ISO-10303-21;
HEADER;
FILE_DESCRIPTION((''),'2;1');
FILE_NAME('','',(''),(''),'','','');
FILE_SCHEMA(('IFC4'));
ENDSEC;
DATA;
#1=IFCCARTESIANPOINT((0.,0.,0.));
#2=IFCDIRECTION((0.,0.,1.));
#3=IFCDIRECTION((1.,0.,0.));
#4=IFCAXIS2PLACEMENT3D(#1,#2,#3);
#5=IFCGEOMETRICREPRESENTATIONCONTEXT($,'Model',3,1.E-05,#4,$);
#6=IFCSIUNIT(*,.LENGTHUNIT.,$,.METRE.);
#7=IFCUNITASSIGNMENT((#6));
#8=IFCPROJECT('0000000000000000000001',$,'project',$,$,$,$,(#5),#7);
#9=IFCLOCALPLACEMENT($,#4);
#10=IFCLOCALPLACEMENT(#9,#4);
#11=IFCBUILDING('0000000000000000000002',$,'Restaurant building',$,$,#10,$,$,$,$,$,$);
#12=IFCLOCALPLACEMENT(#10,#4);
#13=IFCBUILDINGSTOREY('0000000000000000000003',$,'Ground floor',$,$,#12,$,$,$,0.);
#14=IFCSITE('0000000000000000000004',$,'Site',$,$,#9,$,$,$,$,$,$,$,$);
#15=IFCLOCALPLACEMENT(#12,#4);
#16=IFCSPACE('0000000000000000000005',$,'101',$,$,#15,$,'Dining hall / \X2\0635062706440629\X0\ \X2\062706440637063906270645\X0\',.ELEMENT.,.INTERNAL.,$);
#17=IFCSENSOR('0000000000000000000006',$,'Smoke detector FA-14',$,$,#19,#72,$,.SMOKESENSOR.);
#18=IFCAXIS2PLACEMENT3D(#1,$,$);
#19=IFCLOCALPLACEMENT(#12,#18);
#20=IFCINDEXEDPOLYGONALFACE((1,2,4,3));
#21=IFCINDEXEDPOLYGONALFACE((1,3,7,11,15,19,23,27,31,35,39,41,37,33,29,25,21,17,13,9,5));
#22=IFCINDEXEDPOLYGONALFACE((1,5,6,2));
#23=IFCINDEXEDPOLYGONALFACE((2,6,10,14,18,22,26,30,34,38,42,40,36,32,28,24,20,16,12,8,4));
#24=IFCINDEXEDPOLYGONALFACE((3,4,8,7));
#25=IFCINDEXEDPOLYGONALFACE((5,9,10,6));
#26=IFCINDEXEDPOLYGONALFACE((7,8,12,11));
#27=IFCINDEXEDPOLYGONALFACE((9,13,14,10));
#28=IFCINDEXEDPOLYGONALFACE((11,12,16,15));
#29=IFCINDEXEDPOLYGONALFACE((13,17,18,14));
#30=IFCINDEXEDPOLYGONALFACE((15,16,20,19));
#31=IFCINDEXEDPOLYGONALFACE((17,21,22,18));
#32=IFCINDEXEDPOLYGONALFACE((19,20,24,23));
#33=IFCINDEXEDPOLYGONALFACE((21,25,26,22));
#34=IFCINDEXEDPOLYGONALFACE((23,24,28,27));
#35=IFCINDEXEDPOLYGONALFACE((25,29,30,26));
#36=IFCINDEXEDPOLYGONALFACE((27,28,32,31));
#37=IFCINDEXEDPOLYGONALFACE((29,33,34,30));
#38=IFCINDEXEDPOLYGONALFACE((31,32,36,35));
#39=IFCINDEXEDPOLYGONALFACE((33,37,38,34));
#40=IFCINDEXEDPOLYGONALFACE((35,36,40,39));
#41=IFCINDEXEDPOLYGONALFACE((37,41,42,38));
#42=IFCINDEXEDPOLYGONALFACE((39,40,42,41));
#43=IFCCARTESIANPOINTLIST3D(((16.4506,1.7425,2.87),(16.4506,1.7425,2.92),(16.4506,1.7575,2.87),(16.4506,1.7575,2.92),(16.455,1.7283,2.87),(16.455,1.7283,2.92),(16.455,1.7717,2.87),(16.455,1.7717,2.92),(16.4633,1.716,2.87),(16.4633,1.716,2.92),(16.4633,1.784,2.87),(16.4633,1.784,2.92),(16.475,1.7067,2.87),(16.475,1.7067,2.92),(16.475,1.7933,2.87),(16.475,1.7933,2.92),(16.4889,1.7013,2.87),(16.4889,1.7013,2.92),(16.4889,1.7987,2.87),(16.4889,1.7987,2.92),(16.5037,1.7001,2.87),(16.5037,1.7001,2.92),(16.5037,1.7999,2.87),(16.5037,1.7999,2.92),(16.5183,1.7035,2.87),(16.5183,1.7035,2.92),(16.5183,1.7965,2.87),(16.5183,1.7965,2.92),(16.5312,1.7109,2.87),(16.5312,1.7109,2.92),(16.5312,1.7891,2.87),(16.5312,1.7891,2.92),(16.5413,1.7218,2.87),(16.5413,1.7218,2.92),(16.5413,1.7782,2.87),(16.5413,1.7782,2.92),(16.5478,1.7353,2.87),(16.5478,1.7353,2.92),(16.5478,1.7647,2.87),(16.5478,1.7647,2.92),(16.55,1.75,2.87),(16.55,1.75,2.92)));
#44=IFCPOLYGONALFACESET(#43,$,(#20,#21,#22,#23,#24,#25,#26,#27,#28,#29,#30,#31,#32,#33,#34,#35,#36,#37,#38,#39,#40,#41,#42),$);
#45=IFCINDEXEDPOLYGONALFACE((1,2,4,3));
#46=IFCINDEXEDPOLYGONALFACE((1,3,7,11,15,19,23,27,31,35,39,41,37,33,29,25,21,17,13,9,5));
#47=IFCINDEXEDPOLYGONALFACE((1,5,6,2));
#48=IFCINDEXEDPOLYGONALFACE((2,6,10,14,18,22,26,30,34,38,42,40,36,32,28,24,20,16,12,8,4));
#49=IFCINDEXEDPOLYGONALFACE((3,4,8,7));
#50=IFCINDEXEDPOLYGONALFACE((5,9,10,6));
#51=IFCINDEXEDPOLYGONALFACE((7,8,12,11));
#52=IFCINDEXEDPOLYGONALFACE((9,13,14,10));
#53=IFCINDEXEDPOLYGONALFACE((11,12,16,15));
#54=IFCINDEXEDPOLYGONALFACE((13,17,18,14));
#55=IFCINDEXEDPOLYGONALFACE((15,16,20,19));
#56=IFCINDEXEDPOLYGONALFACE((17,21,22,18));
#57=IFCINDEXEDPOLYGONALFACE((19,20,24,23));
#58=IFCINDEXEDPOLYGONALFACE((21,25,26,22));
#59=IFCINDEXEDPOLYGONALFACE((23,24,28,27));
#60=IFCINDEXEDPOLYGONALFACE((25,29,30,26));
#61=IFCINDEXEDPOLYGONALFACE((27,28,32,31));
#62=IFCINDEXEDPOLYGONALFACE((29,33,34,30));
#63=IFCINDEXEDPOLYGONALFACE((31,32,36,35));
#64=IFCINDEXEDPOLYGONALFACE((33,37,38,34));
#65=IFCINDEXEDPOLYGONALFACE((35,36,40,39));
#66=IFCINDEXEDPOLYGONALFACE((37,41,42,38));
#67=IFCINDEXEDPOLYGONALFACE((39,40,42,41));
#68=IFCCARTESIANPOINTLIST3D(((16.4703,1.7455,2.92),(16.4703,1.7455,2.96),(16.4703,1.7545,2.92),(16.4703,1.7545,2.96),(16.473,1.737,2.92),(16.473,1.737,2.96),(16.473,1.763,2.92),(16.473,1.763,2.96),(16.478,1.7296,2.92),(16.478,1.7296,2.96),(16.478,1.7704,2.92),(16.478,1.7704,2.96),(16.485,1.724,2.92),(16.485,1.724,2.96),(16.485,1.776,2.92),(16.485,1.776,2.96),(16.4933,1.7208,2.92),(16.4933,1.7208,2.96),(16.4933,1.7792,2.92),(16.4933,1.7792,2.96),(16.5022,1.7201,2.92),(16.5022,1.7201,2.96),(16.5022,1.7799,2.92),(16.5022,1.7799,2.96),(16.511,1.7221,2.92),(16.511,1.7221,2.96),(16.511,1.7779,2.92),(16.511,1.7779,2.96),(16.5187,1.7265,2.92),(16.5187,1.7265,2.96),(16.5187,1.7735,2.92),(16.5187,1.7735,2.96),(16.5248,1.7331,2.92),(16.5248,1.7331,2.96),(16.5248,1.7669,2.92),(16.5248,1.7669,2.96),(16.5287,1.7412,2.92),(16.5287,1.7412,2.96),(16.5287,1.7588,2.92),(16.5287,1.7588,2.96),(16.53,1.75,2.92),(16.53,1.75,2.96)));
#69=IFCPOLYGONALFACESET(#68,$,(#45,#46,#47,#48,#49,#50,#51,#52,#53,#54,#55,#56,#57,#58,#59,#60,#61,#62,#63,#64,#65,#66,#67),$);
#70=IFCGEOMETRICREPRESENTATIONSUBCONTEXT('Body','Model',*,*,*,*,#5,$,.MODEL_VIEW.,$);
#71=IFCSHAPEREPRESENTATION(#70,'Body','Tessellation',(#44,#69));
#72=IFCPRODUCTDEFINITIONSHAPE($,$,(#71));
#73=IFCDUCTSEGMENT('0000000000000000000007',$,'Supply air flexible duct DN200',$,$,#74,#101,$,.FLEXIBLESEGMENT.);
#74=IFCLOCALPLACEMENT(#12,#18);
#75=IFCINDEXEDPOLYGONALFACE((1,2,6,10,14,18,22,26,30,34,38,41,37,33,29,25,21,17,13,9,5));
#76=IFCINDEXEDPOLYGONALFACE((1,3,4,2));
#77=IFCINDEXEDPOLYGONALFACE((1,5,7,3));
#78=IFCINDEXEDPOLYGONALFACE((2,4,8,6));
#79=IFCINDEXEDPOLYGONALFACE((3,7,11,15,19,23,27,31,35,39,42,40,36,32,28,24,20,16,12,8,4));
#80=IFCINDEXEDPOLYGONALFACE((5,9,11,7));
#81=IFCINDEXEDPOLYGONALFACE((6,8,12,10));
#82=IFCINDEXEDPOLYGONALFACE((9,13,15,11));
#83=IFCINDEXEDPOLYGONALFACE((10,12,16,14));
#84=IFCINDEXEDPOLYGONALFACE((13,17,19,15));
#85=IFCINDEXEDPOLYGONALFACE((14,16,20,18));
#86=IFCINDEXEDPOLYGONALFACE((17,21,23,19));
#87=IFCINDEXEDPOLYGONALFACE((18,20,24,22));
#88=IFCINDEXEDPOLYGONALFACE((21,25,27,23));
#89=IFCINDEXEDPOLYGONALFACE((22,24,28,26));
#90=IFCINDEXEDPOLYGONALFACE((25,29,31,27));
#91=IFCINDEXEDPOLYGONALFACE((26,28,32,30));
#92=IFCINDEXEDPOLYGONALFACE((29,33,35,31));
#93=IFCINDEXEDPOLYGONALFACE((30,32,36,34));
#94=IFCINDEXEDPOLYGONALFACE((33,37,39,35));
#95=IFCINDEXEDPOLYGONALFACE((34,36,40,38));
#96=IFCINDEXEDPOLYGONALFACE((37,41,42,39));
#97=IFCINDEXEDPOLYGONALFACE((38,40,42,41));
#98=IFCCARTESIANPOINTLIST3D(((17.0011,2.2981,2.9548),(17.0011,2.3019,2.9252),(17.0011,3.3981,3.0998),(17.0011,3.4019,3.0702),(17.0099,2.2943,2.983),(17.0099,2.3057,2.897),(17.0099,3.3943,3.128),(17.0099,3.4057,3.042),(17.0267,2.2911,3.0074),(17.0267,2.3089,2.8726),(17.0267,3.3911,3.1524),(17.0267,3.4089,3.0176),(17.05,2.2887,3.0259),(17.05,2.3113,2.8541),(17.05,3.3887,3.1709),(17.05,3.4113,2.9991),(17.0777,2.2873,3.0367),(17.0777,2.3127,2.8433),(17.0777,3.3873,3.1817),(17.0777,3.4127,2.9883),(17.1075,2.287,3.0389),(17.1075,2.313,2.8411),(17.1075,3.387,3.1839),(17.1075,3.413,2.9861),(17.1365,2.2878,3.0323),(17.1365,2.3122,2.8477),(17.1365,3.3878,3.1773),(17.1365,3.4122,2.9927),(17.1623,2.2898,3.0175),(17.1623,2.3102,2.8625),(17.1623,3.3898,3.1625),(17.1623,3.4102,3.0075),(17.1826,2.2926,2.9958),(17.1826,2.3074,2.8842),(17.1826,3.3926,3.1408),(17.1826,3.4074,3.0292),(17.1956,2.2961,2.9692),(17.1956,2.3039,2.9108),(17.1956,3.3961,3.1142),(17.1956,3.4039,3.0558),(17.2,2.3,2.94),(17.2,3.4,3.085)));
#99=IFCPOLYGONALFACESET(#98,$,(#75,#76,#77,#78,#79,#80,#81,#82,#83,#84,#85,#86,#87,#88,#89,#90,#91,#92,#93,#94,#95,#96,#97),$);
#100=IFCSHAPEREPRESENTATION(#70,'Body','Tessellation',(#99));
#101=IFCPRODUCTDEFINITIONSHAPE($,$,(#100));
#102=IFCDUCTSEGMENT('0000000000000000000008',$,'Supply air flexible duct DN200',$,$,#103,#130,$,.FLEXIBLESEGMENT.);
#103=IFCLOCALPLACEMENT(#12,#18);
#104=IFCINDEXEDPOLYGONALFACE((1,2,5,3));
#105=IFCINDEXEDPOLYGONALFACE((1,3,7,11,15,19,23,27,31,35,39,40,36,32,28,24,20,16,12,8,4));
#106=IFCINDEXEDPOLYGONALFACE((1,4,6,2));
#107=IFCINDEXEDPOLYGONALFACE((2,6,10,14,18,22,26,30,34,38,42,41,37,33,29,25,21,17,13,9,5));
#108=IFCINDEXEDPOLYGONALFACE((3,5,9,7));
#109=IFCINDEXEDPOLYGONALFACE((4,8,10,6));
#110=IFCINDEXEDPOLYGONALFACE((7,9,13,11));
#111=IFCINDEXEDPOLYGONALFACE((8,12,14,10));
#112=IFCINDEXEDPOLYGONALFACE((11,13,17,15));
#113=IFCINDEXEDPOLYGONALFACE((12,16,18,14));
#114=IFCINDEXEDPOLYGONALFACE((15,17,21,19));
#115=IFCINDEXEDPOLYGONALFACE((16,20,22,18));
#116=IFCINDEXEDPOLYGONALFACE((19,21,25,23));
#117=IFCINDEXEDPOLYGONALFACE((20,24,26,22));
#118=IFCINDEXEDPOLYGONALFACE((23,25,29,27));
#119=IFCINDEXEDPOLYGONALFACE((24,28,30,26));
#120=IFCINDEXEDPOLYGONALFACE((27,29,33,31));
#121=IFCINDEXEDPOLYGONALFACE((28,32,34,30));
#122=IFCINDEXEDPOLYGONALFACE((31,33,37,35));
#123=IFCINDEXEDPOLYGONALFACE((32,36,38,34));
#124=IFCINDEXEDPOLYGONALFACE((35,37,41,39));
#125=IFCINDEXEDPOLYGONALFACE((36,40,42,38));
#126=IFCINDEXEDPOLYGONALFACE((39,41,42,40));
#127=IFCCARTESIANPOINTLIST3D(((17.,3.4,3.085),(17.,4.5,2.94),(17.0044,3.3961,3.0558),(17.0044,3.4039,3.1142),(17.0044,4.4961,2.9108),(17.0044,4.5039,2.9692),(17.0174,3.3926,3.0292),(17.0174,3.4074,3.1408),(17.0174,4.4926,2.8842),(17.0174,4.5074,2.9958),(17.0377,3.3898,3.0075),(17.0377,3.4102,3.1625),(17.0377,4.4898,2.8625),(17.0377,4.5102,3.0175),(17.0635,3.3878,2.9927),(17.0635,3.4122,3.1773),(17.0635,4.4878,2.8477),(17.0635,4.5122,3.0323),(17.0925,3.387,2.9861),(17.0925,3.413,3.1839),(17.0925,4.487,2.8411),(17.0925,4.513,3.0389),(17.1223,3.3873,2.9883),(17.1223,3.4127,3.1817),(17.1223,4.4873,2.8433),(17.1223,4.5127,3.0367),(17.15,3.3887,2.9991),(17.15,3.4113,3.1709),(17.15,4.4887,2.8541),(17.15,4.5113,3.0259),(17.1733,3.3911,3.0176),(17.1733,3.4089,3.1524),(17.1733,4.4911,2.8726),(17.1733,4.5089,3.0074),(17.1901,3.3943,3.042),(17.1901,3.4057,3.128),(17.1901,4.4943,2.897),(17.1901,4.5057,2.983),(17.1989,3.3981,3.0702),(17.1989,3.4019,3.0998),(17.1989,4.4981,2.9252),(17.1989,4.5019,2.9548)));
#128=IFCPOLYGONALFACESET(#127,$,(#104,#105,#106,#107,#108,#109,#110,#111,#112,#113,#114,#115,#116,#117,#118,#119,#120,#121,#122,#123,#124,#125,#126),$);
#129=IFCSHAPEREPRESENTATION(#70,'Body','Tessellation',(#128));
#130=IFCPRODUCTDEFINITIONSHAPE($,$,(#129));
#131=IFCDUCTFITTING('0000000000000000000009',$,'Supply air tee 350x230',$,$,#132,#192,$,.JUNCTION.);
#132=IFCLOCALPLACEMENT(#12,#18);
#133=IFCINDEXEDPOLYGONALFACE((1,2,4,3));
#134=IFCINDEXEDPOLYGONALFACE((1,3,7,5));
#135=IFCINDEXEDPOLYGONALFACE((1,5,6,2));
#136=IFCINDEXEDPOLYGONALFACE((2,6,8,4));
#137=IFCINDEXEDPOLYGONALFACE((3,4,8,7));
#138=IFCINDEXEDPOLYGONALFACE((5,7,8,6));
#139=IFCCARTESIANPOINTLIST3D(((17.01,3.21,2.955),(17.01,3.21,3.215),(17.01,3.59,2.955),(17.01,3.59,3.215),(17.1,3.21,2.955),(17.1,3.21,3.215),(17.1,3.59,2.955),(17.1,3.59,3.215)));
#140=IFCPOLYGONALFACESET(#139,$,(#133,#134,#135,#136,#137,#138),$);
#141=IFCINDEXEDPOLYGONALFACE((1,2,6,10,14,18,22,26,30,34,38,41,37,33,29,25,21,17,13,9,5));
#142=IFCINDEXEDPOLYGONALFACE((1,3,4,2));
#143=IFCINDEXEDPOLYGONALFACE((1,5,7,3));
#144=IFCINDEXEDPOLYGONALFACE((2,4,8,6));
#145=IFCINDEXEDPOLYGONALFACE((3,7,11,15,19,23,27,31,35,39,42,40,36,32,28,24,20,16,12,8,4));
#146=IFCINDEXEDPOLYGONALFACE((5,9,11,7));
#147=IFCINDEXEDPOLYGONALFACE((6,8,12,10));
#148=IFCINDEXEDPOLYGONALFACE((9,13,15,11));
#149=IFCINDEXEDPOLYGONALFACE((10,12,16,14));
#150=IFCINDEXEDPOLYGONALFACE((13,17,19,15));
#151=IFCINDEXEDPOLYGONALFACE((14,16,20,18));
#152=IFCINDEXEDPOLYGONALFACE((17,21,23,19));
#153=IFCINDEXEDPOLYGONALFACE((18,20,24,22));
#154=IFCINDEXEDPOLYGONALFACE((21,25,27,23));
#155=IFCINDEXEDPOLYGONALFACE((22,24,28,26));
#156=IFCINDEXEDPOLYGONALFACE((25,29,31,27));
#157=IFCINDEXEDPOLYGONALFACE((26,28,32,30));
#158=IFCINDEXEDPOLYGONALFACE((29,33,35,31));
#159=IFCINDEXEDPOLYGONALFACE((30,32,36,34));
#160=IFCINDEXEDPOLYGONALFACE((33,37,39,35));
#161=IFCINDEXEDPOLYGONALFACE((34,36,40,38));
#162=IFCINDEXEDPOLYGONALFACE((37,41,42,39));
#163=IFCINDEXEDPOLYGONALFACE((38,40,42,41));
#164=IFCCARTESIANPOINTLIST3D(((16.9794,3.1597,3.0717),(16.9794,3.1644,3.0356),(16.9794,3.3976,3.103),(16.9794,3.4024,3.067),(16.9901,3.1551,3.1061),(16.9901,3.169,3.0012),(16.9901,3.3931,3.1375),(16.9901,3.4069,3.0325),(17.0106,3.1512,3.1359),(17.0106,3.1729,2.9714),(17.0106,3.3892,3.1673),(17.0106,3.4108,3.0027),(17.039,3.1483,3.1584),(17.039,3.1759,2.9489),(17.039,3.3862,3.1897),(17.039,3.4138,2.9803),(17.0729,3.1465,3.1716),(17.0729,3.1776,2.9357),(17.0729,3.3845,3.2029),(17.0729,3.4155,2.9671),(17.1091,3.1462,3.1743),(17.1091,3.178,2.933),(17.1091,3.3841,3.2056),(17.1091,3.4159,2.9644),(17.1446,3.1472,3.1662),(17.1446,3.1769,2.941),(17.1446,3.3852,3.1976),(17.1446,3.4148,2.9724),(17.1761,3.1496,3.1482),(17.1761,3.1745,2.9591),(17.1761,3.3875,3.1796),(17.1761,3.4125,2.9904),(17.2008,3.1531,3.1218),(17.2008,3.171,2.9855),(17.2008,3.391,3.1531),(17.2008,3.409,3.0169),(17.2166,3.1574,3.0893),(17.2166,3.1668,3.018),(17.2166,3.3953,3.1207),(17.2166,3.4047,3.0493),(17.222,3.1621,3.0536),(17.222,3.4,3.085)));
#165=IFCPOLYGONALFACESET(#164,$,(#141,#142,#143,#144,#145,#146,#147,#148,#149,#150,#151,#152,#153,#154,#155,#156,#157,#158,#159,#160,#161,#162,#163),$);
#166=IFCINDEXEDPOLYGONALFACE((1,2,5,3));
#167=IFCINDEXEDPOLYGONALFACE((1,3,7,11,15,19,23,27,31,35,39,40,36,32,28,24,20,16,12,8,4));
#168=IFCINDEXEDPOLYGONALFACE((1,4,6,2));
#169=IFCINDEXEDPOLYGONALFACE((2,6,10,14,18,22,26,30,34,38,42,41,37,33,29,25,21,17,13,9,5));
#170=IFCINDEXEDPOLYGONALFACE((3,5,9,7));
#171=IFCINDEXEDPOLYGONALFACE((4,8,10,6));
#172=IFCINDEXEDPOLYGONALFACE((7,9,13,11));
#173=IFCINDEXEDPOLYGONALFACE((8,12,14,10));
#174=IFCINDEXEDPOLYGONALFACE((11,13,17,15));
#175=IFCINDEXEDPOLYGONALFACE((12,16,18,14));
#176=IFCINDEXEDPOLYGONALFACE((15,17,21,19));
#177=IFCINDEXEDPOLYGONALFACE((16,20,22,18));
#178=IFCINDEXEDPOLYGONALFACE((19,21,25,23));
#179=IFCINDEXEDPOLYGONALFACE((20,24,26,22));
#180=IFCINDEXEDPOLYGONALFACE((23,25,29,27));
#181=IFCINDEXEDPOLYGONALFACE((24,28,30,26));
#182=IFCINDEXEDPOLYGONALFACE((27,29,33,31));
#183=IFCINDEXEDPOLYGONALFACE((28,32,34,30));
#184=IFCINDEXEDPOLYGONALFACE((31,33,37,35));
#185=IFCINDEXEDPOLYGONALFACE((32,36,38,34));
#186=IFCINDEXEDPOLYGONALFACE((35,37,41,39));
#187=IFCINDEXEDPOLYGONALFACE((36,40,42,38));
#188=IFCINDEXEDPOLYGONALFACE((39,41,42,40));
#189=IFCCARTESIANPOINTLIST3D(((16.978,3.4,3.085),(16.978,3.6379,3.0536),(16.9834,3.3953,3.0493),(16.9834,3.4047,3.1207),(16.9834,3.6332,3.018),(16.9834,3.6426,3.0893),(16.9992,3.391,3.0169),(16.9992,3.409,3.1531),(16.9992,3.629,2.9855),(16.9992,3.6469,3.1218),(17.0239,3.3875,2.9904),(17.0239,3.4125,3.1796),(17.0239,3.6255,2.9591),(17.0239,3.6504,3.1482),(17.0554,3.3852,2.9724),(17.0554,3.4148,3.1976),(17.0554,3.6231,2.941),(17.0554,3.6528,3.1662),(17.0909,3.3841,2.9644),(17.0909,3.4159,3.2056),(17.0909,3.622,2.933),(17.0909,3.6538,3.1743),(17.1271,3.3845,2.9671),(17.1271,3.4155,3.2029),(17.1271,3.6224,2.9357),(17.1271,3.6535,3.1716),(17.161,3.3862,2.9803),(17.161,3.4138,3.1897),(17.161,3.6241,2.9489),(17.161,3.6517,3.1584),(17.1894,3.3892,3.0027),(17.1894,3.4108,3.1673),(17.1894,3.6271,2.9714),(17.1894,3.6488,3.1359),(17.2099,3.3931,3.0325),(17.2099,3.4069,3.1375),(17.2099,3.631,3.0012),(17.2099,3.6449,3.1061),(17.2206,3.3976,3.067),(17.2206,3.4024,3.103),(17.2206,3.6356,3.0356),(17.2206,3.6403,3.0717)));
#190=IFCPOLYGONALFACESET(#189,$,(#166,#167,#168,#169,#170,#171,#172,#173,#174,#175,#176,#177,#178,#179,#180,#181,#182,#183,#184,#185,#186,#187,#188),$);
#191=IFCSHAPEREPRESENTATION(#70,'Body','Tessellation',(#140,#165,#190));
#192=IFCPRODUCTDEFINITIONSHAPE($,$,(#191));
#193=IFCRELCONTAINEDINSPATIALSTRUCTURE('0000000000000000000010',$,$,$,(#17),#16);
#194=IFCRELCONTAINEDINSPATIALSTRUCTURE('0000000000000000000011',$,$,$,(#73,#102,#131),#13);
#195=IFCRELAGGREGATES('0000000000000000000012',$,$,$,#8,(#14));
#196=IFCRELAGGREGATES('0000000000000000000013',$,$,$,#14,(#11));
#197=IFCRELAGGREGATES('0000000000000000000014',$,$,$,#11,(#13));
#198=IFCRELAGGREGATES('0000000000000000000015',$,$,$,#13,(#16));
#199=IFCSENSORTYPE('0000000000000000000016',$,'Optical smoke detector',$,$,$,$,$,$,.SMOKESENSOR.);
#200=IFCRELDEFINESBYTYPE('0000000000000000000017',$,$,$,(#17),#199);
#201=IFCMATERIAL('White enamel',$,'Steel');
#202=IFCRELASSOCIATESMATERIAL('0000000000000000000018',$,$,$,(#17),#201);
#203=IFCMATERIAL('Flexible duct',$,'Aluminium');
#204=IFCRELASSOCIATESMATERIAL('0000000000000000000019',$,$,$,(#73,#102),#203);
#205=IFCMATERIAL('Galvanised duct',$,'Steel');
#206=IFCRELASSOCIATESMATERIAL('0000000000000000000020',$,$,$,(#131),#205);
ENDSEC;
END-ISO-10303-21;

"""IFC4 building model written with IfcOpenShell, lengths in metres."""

from ifc_helpers import new_model, si_unit, frame, origin, origin_with_axes, origin_2d, place, context, subcontext, project, spatial, rectangle, circle, extrude, source, transform, mapped, material, type_object, type_shapes, element, save


model = new_model("IFC4")

# Units and contexts
model_context = context("Model", 3, precision=1e-05, world=origin_with_axes())
body_context = subcontext(model_context, "Body", "Model", "MODEL_VIEW")
ifc_project = project(units=[si_unit("LENGTHUNIT", "METRE")], contexts=[model_context])

# Site, building, storey
site_placement = place(None, origin_with_axes())
site = spatial("IfcSite", under=ifc_project, at=site_placement, Name="Site")
building_placement = place(site_placement, origin_with_axes())
building = spatial("IfcBuilding", under=site, at=building_placement, Name="Restaurant building")
storey_placement = place(building_placement, origin_with_axes())
storey = spatial("IfcBuildingStorey", under=building, at=storey_placement, Name="Ground floor", Elevation=0.0)

# Shared definitions
ifc_material_1 = material(Name="White enamel", Category="Steel")

# Shared definitions
space_placement = place(storey_placement, origin_with_axes())
space = spatial("IfcSpace", under=storey, at=space_placement, Name="101", LongName="Dining hall / صالة الطعام", CompositionType="ELEMENT", PredefinedType="INTERNAL")

# Sensor
sensor_type = type_object("IfcSensorType", Name="Optical smoke detector", PredefinedType="SMOKESENSOR")
shared_shape_1 = source(origin(), body_context, "Body", "SweptSolid", [
    extrude(circle(Radius=0.05, at=origin_2d()), frame((0.0, 0.0, -0.09)), (0.0, 0.0, 1.0), 0.05),
    extrude(circle(Radius=0.03, at=origin_2d()), frame((0.0, 0.0, -0.04)), (0.0, 0.0, 1.0), 0.04),
])
type_shapes(sensor_type, [shared_shape_1])
sensor_placement = place(storey_placement, frame((16.5, 1.75, 2.96)))
element("IfcSensor", 1, at=sensor_placement, inside=space, type_object=sensor_type, material=ifc_material_1, Name="Smoke detector FA-14", PredefinedType="SMOKESENSOR", context=body_context, shape_type="MappedRepresentation", body=[
    mapped(shared_shape_1, transform((0.0, 0.0, 0.0))),
])

# Duct segments
ifc_material_2 = material(Name="Flexible duct", Category="Aluminium")
duct_segment_1_placement = place(storey_placement, frame((17.1, 3.4, 3.085)))
element("IfcDuctSegment", 2, at=duct_segment_1_placement, inside=storey, material=ifc_material_2, Name="Supply air flexible duct DN200", PredefinedType="FLEXIBLESEGMENT", context=body_context, shape_type="SweptSolid", body=[
    extrude(circle(Radius=0.1, at=origin_2d()), frame((0.0, 0.0, 0.0), z_axis=(0.0, -0.991424, -0.130688), x_axis=(1.0, 0.0, 0.0)), (0.0, 0.0, 1.0), 1.1095),
])
duct_segment_2_placement = place(storey_placement, frame((17.1, 3.4, 3.085)))
element("IfcDuctSegment", 3, at=duct_segment_2_placement, inside=storey, material=ifc_material_2, Name="Supply air flexible duct DN200", PredefinedType="FLEXIBLESEGMENT", context=body_context, shape_type="SweptSolid", body=[
    extrude(circle(Radius=0.1, at=origin_2d()), frame((0.0, 0.0, 0.0), z_axis=(0.0, 0.991424, -0.130688), x_axis=(-1.0, 0.0, 0.0)), (0.0, 0.0, 1.0), 1.1095),
])

# Duct fitting
ifc_material_3 = material(Name="Galvanised duct", Category="Steel")
duct_fitting_placement = place(storey_placement, frame((17.1, 3.4, 3.085)))
element("IfcDuctFitting", 4, at=duct_fitting_placement, inside=storey, material=ifc_material_3, Name="Supply air tee 350x230", PredefinedType="JUNCTION", context=body_context, shape_type="SweptSolid", body=[
    extrude(rectangle(XDim=0.38, YDim=0.26, at=origin_2d()), frame((0.0, 0.0, 0.0), z_axis=(-1.0, 0.0, 0.0), x_axis=(0.0, -1.0, 0.0)), (0.0, 0.0, 1.0), 0.09),
    extrude(circle(Radius=0.122, at=origin_2d()), frame((0.0, 0.0, 0.0), z_axis=(0.0, -0.991424, -0.130688), x_axis=(1.0, 0.0, 0.0)), (0.0, 0.0, 1.0), 0.24),
    extrude(circle(Radius=0.122, at=origin_2d()), frame((0.0, 0.0, 0.0), z_axis=(0.0, 0.991424, -0.130688), x_axis=(-1.0, 0.0, 0.0)), (0.0, 0.0, 1.0), 0.24),
])

save(model, "model.ifc")
